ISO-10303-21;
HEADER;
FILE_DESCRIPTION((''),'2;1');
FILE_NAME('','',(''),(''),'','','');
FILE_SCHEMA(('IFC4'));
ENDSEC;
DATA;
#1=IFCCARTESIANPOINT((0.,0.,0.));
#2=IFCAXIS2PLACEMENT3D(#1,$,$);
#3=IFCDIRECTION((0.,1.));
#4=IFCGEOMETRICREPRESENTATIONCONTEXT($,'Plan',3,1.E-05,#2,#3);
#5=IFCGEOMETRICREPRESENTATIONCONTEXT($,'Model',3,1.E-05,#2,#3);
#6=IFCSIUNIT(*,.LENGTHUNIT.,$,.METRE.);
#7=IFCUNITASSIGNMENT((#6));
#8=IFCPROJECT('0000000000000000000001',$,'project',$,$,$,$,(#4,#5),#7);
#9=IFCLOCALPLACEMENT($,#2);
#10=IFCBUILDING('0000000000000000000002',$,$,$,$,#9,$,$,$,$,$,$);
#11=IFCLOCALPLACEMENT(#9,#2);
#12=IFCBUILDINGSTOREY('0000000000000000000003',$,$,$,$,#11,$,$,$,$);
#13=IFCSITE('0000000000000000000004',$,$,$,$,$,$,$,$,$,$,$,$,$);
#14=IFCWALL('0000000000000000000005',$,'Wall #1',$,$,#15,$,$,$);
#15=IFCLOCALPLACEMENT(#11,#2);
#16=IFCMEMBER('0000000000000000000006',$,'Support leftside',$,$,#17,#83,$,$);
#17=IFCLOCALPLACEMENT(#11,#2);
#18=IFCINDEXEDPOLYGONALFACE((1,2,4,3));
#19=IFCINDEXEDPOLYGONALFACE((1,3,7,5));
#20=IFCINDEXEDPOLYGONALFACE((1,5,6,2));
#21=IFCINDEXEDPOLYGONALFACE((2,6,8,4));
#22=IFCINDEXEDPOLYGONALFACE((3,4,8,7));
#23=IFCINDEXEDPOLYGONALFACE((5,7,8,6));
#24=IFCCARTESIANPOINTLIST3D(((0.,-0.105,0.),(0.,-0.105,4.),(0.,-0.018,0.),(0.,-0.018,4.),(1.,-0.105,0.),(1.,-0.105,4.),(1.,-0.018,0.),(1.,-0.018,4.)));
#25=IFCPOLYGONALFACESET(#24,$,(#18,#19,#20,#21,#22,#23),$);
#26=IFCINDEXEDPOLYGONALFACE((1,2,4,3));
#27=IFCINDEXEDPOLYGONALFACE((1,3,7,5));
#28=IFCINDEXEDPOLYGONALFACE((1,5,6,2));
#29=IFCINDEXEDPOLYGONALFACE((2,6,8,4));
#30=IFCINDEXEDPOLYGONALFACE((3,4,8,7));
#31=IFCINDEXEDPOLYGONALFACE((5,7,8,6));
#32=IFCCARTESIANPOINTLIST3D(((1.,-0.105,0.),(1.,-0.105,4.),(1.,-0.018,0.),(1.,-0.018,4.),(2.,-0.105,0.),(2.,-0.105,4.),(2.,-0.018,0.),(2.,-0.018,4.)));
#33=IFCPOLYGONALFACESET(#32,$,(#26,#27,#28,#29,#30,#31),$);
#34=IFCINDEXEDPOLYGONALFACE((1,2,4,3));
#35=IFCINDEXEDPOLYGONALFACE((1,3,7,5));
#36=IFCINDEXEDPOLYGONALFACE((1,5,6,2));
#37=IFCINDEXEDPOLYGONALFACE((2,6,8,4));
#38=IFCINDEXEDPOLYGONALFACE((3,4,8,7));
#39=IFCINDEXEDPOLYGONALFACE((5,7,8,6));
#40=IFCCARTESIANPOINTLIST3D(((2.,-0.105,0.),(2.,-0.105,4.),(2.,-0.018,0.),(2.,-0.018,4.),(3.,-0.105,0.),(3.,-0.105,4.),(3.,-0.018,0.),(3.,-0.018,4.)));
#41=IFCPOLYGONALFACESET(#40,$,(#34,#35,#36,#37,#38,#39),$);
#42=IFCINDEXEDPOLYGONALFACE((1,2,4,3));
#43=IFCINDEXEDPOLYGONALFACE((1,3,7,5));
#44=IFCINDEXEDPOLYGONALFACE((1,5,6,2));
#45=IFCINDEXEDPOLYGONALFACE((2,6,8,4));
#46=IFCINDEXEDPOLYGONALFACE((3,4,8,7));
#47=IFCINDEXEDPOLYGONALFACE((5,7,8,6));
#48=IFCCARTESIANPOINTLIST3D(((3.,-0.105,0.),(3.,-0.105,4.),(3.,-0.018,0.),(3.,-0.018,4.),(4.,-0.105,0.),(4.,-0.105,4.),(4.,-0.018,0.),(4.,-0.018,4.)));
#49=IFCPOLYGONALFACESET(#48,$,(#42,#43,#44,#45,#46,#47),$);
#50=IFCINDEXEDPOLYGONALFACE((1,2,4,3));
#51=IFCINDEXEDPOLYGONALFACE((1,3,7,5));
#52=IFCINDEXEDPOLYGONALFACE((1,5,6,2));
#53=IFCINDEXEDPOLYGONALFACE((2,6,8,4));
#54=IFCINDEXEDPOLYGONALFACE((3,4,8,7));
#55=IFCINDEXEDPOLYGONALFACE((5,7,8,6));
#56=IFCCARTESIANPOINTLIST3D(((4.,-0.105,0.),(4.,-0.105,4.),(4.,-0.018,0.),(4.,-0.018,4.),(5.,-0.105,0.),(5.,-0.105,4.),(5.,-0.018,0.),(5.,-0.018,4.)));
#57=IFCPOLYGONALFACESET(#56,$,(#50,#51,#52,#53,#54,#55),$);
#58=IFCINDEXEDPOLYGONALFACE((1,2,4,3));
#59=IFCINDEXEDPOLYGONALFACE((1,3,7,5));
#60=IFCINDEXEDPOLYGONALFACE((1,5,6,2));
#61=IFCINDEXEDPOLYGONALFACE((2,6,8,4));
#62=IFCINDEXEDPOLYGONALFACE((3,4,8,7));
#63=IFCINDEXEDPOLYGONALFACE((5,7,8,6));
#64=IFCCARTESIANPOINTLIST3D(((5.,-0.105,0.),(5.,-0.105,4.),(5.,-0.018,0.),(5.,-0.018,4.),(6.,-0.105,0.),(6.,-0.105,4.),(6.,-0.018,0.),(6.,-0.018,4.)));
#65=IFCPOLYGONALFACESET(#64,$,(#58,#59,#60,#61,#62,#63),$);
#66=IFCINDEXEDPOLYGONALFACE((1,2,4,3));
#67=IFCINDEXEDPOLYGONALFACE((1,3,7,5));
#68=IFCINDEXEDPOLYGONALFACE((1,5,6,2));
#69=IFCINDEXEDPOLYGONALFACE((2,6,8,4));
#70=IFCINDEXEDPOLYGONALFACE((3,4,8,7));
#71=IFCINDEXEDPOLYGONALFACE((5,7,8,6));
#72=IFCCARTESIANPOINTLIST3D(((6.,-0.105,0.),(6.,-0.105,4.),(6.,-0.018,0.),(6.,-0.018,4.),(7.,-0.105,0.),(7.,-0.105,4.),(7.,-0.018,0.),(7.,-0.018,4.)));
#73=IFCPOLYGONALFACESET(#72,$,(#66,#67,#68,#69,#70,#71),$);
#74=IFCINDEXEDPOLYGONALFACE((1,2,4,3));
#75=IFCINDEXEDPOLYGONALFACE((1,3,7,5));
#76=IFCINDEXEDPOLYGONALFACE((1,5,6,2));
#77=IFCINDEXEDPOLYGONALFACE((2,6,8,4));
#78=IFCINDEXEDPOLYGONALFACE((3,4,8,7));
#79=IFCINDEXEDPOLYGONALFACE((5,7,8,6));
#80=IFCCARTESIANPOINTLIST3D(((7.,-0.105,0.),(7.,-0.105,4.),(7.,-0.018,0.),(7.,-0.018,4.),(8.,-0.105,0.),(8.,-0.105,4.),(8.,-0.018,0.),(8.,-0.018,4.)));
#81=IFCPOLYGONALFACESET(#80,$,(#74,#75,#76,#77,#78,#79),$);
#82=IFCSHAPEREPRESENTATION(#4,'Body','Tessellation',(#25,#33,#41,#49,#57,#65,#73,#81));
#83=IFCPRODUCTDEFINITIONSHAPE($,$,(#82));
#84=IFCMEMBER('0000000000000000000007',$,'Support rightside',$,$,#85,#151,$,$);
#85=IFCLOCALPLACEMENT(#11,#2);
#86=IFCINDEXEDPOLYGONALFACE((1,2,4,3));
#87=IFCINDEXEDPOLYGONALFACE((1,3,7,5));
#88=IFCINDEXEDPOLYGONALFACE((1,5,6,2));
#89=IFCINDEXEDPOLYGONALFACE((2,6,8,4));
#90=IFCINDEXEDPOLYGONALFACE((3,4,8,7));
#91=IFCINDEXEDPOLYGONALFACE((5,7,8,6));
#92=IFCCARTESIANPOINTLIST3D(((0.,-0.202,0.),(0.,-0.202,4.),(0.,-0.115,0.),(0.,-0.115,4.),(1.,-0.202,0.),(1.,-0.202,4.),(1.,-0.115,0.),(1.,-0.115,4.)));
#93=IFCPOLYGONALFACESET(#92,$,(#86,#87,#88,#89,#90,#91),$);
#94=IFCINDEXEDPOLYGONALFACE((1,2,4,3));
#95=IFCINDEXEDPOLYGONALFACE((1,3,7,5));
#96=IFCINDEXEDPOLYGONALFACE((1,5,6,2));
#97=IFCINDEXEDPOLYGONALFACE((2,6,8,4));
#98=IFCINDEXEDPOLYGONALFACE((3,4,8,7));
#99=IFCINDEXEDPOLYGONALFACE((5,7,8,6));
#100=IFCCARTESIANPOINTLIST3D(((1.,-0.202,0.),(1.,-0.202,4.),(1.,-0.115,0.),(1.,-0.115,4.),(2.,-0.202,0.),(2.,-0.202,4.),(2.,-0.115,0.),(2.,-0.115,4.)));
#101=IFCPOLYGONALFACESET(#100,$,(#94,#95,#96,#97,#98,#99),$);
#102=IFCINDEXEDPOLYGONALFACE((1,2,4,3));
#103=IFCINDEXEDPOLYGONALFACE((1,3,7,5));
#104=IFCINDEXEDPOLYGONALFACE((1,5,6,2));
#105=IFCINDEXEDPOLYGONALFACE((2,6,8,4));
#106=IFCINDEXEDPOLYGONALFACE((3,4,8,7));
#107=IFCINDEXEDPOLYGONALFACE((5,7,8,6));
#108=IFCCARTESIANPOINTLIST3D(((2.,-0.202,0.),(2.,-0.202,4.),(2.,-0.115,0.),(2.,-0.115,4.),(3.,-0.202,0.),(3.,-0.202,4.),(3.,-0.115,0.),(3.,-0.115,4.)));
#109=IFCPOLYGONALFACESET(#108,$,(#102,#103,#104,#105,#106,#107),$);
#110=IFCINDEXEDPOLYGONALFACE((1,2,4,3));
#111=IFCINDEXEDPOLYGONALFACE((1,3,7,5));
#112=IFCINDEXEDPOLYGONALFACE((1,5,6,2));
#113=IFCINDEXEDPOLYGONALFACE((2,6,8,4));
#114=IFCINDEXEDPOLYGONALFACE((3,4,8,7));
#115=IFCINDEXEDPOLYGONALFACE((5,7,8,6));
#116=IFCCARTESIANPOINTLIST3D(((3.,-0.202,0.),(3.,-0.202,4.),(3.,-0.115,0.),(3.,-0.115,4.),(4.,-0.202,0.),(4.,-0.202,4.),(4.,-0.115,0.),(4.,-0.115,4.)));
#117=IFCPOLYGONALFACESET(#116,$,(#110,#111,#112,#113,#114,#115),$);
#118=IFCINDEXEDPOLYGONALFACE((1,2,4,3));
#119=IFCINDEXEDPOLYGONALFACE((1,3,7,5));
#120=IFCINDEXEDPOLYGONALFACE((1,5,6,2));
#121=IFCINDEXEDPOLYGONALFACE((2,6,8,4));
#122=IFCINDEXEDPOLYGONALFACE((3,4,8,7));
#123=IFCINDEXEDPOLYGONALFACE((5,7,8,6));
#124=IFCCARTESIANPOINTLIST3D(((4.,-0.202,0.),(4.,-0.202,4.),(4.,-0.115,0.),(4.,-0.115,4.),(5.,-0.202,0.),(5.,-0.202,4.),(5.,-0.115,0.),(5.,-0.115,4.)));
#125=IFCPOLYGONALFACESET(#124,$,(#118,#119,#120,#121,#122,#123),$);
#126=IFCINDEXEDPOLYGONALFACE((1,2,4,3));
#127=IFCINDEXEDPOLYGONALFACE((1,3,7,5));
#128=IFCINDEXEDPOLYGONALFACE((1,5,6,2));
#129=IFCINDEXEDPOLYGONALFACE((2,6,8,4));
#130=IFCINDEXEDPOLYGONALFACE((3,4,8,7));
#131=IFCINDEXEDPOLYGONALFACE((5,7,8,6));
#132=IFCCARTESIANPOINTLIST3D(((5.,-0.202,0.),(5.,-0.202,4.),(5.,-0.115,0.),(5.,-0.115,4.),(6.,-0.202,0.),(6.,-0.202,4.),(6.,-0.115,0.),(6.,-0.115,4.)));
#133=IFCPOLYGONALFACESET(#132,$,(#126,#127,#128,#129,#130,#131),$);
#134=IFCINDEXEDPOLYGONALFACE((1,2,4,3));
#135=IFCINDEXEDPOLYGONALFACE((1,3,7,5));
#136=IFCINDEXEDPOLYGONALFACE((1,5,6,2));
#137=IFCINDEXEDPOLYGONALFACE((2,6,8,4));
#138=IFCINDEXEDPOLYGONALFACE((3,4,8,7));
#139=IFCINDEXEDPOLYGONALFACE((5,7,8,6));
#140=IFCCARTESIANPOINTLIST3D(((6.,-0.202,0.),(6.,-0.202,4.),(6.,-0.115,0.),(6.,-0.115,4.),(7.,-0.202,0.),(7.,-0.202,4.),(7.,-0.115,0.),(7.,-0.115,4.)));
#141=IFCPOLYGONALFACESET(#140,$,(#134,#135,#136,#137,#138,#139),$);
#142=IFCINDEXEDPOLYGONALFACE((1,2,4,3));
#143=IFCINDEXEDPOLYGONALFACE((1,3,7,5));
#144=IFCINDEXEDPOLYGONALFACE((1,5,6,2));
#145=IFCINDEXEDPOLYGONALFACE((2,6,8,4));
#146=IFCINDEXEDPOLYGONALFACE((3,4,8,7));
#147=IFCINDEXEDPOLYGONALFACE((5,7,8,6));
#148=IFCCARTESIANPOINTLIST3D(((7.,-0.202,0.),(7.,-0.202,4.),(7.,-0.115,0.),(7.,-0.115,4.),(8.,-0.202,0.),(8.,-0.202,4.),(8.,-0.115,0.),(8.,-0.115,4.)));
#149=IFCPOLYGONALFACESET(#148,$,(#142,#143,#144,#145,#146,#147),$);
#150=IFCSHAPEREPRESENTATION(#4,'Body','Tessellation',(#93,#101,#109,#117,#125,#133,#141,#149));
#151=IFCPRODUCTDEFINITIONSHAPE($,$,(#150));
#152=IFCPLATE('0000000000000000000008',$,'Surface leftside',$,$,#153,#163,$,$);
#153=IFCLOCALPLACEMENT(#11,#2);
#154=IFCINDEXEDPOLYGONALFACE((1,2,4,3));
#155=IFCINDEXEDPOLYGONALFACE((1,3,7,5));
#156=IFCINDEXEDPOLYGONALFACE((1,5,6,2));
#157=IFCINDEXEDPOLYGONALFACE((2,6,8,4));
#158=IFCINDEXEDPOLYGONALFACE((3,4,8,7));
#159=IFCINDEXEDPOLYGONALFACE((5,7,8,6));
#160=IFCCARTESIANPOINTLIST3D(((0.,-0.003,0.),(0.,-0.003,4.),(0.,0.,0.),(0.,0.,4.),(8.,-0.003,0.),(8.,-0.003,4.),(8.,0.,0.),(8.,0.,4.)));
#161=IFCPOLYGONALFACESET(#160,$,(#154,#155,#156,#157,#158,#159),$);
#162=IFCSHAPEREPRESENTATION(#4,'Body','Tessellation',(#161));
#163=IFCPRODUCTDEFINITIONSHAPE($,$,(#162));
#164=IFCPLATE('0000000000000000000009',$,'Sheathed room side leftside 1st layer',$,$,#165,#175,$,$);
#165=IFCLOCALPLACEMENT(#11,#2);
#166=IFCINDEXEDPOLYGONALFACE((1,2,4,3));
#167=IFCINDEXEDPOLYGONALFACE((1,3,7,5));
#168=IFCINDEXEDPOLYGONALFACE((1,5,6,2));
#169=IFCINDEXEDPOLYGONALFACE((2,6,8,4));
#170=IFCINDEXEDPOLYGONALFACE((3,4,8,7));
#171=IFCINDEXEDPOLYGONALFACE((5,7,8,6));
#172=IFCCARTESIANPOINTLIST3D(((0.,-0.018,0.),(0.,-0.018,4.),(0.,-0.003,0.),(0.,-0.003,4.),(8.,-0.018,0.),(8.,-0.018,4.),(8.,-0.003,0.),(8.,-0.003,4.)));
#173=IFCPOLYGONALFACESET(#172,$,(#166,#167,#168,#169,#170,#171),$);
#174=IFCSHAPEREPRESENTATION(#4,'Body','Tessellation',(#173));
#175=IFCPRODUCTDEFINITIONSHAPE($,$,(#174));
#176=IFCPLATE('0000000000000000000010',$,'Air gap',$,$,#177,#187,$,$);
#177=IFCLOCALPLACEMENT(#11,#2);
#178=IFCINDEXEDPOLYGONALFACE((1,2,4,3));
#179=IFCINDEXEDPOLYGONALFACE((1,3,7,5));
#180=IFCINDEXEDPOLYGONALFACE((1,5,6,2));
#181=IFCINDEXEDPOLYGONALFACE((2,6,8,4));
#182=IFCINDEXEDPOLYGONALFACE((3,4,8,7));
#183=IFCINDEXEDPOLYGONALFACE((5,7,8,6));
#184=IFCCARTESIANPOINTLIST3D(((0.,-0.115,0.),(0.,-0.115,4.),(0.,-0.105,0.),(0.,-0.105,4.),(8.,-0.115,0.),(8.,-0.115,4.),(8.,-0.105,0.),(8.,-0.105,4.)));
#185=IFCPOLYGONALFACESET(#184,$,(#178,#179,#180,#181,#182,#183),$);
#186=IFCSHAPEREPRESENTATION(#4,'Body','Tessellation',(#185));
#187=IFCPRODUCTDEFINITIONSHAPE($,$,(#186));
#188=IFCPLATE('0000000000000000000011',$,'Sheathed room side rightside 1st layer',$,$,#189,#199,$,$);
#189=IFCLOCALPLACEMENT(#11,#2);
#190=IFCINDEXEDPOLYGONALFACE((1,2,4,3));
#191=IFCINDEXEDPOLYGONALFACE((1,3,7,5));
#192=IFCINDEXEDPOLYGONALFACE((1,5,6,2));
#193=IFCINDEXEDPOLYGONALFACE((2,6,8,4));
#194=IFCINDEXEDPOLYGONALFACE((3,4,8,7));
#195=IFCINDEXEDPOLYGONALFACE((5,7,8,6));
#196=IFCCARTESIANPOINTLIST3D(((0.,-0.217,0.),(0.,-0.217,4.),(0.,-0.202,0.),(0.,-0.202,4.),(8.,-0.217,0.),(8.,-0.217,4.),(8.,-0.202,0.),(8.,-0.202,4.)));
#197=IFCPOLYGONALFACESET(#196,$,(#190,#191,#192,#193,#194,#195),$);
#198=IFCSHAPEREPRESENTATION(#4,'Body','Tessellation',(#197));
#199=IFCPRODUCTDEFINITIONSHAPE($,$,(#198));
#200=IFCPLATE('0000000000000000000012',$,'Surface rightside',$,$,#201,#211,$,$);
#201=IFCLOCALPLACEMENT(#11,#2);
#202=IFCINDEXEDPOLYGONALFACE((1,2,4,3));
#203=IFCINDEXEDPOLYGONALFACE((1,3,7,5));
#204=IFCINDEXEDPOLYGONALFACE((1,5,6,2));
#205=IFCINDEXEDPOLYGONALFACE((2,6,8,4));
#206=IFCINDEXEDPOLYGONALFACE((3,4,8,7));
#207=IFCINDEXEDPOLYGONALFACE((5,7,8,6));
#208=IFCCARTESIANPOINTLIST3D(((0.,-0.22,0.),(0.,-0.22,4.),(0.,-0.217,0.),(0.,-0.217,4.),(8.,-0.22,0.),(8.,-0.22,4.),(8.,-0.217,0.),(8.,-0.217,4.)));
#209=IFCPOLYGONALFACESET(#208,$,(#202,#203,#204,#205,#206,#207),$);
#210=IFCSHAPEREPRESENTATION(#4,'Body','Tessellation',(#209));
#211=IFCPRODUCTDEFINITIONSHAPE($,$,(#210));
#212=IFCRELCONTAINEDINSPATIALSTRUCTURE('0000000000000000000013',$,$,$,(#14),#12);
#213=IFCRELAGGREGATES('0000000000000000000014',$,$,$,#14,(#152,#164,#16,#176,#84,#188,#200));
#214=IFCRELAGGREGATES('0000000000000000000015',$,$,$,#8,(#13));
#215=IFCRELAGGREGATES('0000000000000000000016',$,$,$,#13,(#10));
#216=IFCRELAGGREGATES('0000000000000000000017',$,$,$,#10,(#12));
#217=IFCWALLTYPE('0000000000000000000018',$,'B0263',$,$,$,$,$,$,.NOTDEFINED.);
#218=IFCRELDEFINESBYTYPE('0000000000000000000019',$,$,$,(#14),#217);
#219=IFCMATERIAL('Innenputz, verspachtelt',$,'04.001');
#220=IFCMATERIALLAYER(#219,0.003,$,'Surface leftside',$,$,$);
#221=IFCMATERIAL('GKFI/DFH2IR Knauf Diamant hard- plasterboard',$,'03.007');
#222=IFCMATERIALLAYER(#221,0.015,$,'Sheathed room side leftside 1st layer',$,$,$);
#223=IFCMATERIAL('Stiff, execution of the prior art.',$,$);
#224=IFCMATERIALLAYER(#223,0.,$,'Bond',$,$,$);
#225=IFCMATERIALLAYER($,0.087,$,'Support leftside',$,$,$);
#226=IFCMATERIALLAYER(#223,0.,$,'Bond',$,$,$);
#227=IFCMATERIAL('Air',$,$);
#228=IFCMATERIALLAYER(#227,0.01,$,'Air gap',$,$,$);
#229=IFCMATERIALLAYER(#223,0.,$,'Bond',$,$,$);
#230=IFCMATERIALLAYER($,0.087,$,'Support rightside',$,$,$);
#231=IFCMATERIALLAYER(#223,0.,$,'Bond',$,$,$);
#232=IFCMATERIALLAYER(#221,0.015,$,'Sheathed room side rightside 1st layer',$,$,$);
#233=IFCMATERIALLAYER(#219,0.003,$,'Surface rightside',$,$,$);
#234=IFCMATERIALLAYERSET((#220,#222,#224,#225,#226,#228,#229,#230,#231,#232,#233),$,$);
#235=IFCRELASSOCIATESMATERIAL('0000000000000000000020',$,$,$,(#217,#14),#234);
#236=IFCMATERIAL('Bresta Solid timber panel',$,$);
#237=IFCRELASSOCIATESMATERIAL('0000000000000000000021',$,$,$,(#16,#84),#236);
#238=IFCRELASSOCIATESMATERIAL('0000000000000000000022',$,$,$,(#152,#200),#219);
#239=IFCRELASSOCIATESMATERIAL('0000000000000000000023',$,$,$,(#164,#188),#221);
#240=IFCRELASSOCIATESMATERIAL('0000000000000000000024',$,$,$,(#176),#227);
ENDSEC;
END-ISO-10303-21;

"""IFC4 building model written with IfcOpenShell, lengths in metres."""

from ifc_helpers import new_model, si_unit, direction, frame, frame_2d, origin, origin_with_axes, place, context, project, spatial, rectangle, extrude, material, layer, layer_set, type_object, element, aggregate, save


model = new_model("IFC4")

# Units and contexts
plan_context = context("Plan", 3, precision=1e-05, world=origin(), true_north=direction((0.0, 1.0)))
model_context = context("Model", 3, precision=1e-05, world=origin(), true_north=direction((0.0, 1.0)))
ifc_project = project(units=[si_unit("LENGTHUNIT", "METRE")], contexts=[plan_context, model_context])

# Site, building, storey
site = spatial("IfcSite", under=ifc_project)
building_placement = place(None, origin())
building = spatial("IfcBuilding", under=site, at=building_placement)
storey_placement = place(building_placement, origin())
storey = spatial("IfcBuildingStorey", under=building, at=storey_placement)

# Wall, members, plates
ifc_material_1 = material(Name="Innenputz, verspachtelt", Category="04.001")
ifc_layer_1 = layer(ifc_material_1, 0.003, Name="Surface leftside")
ifc_material_2 = material(Name="GKFI/DFH2IR Knauf Diamant hard- plasterboard", Category="03.007")
ifc_layer_2 = layer(ifc_material_2, 0.015, Name="Sheathed room side leftside 1st layer")
ifc_material_3 = material(Name="Stiff, execution of the prior art.")
ifc_layer_3 = layer(ifc_material_3, 0.0, Name="Bond")
ifc_layer_4 = layer(None, 0.087, Name="Support leftside")
ifc_layer_5 = layer(ifc_material_3, 0.0, Name="Bond")
ifc_material_4 = material(Name="Air")
ifc_layer_6 = layer(ifc_material_4, 0.01, Name="Air gap")
ifc_layer_7 = layer(ifc_material_3, 0.0, Name="Bond")
ifc_layer_8 = layer(None, 0.087, Name="Support rightside")
ifc_layer_9 = layer(ifc_material_3, 0.0, Name="Bond")
ifc_layer_10 = layer(ifc_material_2, 0.015, Name="Sheathed room side rightside 1st layer")
ifc_layer_11 = layer(ifc_material_1, 0.003, Name="Surface rightside")
ifc_layer_set = layer_set([ifc_layer_1, ifc_layer_2, ifc_layer_3, ifc_layer_4, ifc_layer_5, ifc_layer_6, ifc_layer_7, ifc_layer_8, ifc_layer_9, ifc_layer_10, ifc_layer_11])
wall_type = type_object("IfcWallType", Name="B0263", PredefinedType="NOTDEFINED", material=ifc_layer_set)
wall_placement = place(None, frame((0.0, 0.0, 0.0), z_axis=(0.0, -1.0, 0.0), x_axis=(1.0, 0.0, 0.0)))
wall = element("IfcWall", 1, at=wall_placement, inside=storey, type_object=wall_type, material=ifc_layer_set, Name="Wall #1")
ifc_material_5 = material(Name="Bresta Solid timber panel")
member_1_placement = place(wall_placement, origin())
member_1 = element("IfcMember", 2, at=member_1_placement, material=ifc_material_5, Name="Support leftside", context=plan_context, shape_type="SweptSolid", body=[
    extrude(rectangle(XDim=1.0, YDim=0.087, at=frame_2d((0.5, 0.0435), x_axis=(1.0, 0.0))), frame((0.0, 4.0, 0.018), z_axis=(0.0, -1.0, 0.0), x_axis=(1.0, 0.0, 0.0)), (0.0, 0.0, 1.0), 4.0),
    extrude(rectangle(XDim=1.0, YDim=0.087, at=frame_2d((0.5, 0.0435), x_axis=(1.0, 0.0))), frame((1.0, 4.0, 0.018), z_axis=(0.0, -1.0, 0.0), x_axis=(1.0, 0.0, 0.0)), (0.0, 0.0, 1.0), 4.0),
    extrude(rectangle(XDim=1.0, YDim=0.087, at=frame_2d((0.5, 0.0435), x_axis=(1.0, 0.0))), frame((2.0, 4.0, 0.018), z_axis=(0.0, -1.0, 0.0), x_axis=(1.0, 0.0, 0.0)), (0.0, 0.0, 1.0), 4.0),
    extrude(rectangle(XDim=1.0, YDim=0.087, at=frame_2d((0.5, 0.0435), x_axis=(1.0, 0.0))), frame((3.0, 4.0, 0.018), z_axis=(0.0, -1.0, 0.0), x_axis=(1.0, 0.0, 0.0)), (0.0, 0.0, 1.0), 4.0),
    extrude(rectangle(XDim=1.0, YDim=0.087, at=frame_2d((0.5, 0.0435), x_axis=(1.0, 0.0))), frame((4.0, 4.0, 0.018), z_axis=(0.0, -1.0, 0.0), x_axis=(1.0, 0.0, 0.0)), (0.0, 0.0, 1.0), 4.0),
    extrude(rectangle(XDim=1.0, YDim=0.087, at=frame_2d((0.5, 0.0435), x_axis=(1.0, 0.0))), frame((5.0, 4.0, 0.018), z_axis=(0.0, -1.0, 0.0), x_axis=(1.0, 0.0, 0.0)), (0.0, 0.0, 1.0), 4.0),
    extrude(rectangle(XDim=1.0, YDim=0.087, at=frame_2d((0.5, 0.0435), x_axis=(1.0, 0.0))), frame((6.0, 4.0, 0.018), z_axis=(0.0, -1.0, 0.0), x_axis=(1.0, 0.0, 0.0)), (0.0, 0.0, 1.0), 4.0),
    extrude(rectangle(XDim=1.0, YDim=0.087, at=frame_2d((0.5, 0.0435), x_axis=(1.0, 0.0))), frame((7.0, 4.0, 0.018), z_axis=(0.0, -1.0, 0.0), x_axis=(1.0, 0.0, 0.0)), (0.0, 0.0, 1.0), 4.0),
])
member_2_placement = place(wall_placement, origin())
member_2 = element("IfcMember", 3, at=member_2_placement, material=ifc_material_5, Name="Support rightside", context=plan_context, shape_type="SweptSolid", body=[
    extrude(rectangle(XDim=1.0, YDim=0.087, at=frame_2d((0.5, 0.0435), x_axis=(1.0, 0.0))), frame((0.0, 4.0, 0.115), z_axis=(0.0, -1.0, 0.0), x_axis=(1.0, 0.0, 0.0)), (0.0, 0.0, 1.0), 4.0),
    extrude(rectangle(XDim=1.0, YDim=0.087, at=frame_2d((0.5, 0.0435), x_axis=(1.0, 0.0))), frame((1.0, 4.0, 0.115), z_axis=(0.0, -1.0, 0.0), x_axis=(1.0, 0.0, 0.0)), (0.0, 0.0, 1.0), 4.0),
    extrude(rectangle(XDim=1.0, YDim=0.087, at=frame_2d((0.5, 0.0435), x_axis=(1.0, 0.0))), frame((2.0, 4.0, 0.115), z_axis=(0.0, -1.0, 0.0), x_axis=(1.0, 0.0, 0.0)), (0.0, 0.0, 1.0), 4.0),
    extrude(rectangle(XDim=1.0, YDim=0.087, at=frame_2d((0.5, 0.0435), x_axis=(1.0, 0.0))), frame((3.0, 4.0, 0.115), z_axis=(0.0, -1.0, 0.0), x_axis=(1.0, 0.0, 0.0)), (0.0, 0.0, 1.0), 4.0),
    extrude(rectangle(XDim=1.0, YDim=0.087, at=frame_2d((0.5, 0.0435), x_axis=(1.0, 0.0))), frame((4.0, 4.0, 0.115), z_axis=(0.0, -1.0, 0.0), x_axis=(1.0, 0.0, 0.0)), (0.0, 0.0, 1.0), 4.0),
    extrude(rectangle(XDim=1.0, YDim=0.087, at=frame_2d((0.5, 0.0435), x_axis=(1.0, 0.0))), frame((5.0, 4.0, 0.115), z_axis=(0.0, -1.0, 0.0), x_axis=(1.0, 0.0, 0.0)), (0.0, 0.0, 1.0), 4.0),
    extrude(rectangle(XDim=1.0, YDim=0.087, at=frame_2d((0.5, 0.0435), x_axis=(1.0, 0.0))), frame((6.0, 4.0, 0.115), z_axis=(0.0, -1.0, 0.0), x_axis=(1.0, 0.0, 0.0)), (0.0, 0.0, 1.0), 4.0),
    extrude(rectangle(XDim=1.0, YDim=0.087, at=frame_2d((0.5, 0.0435), x_axis=(1.0, 0.0))), frame((7.0, 4.0, 0.115), z_axis=(0.0, -1.0, 0.0), x_axis=(1.0, 0.0, 0.0)), (0.0, 0.0, 1.0), 4.0),
])
plate_1_placement = place(wall_placement, origin())
plate_1 = element("IfcPlate", 4, at=plate_1_placement, material=ifc_material_1, Name="Surface leftside", context=plan_context, shape_type="SweptSolid", body=[
    extrude(rectangle(XDim=8.0, YDim=4.0, at=frame_2d((4.0, 2.0), x_axis=(1.0, 0.0))), origin_with_axes(), (0.0, 0.0, 1.0), 0.003),
])
plate_2_placement = place(wall_placement, origin())
plate_2 = element("IfcPlate", 5, at=plate_2_placement, material=ifc_material_2, Name="Sheathed room side leftside 1st layer", context=plan_context, shape_type="SweptSolid", body=[
    extrude(rectangle(XDim=8.0, YDim=4.0, at=frame_2d((4.0, 2.0), x_axis=(1.0, 0.0))), frame((0.0, 0.0, 0.003), z_axis=(0.0, 0.0, 1.0), x_axis=(1.0, 0.0, 0.0)), (0.0, 0.0, 1.0), 0.015),
])
plate_3_placement = place(wall_placement, origin())
plate_3 = element("IfcPlate", 6, at=plate_3_placement, material=ifc_material_4, Name="Air gap", context=plan_context, shape_type="SweptSolid", body=[
    extrude(rectangle(XDim=8.0, YDim=4.0, at=frame_2d((4.0, 2.0), x_axis=(1.0, 0.0))), frame((0.0, 0.0, 0.105), z_axis=(0.0, 0.0, 1.0), x_axis=(1.0, 0.0, 0.0)), (0.0, 0.0, 1.0), 0.01),
])
plate_4_placement = place(wall_placement, origin())
plate_4 = element("IfcPlate", 7, at=plate_4_placement, material=ifc_material_2, Name="Sheathed room side rightside 1st layer", context=plan_context, shape_type="SweptSolid", body=[
    extrude(rectangle(XDim=8.0, YDim=4.0, at=frame_2d((4.0, 2.0), x_axis=(1.0, 0.0))), frame((0.0, 0.0, 0.202), z_axis=(0.0, 0.0, 1.0), x_axis=(1.0, 0.0, 0.0)), (0.0, 0.0, 1.0), 0.015),
])
plate_5_placement = place(wall_placement, origin())
plate_5 = element("IfcPlate", 8, at=plate_5_placement, material=ifc_material_1, Name="Surface rightside", context=plan_context, shape_type="SweptSolid", body=[
    extrude(rectangle(XDim=8.0, YDim=4.0, at=frame_2d((4.0, 2.0), x_axis=(1.0, 0.0))), frame((0.0, 0.0, 0.217), z_axis=(0.0, 0.0, 1.0), x_axis=(1.0, 0.0, 0.0)), (0.0, 0.0, 1.0), 0.003),
])
aggregate(wall, [plate_1, plate_2, member_1, plate_3, member_2, plate_4, plate_5])

save(model, "model.ifc")
